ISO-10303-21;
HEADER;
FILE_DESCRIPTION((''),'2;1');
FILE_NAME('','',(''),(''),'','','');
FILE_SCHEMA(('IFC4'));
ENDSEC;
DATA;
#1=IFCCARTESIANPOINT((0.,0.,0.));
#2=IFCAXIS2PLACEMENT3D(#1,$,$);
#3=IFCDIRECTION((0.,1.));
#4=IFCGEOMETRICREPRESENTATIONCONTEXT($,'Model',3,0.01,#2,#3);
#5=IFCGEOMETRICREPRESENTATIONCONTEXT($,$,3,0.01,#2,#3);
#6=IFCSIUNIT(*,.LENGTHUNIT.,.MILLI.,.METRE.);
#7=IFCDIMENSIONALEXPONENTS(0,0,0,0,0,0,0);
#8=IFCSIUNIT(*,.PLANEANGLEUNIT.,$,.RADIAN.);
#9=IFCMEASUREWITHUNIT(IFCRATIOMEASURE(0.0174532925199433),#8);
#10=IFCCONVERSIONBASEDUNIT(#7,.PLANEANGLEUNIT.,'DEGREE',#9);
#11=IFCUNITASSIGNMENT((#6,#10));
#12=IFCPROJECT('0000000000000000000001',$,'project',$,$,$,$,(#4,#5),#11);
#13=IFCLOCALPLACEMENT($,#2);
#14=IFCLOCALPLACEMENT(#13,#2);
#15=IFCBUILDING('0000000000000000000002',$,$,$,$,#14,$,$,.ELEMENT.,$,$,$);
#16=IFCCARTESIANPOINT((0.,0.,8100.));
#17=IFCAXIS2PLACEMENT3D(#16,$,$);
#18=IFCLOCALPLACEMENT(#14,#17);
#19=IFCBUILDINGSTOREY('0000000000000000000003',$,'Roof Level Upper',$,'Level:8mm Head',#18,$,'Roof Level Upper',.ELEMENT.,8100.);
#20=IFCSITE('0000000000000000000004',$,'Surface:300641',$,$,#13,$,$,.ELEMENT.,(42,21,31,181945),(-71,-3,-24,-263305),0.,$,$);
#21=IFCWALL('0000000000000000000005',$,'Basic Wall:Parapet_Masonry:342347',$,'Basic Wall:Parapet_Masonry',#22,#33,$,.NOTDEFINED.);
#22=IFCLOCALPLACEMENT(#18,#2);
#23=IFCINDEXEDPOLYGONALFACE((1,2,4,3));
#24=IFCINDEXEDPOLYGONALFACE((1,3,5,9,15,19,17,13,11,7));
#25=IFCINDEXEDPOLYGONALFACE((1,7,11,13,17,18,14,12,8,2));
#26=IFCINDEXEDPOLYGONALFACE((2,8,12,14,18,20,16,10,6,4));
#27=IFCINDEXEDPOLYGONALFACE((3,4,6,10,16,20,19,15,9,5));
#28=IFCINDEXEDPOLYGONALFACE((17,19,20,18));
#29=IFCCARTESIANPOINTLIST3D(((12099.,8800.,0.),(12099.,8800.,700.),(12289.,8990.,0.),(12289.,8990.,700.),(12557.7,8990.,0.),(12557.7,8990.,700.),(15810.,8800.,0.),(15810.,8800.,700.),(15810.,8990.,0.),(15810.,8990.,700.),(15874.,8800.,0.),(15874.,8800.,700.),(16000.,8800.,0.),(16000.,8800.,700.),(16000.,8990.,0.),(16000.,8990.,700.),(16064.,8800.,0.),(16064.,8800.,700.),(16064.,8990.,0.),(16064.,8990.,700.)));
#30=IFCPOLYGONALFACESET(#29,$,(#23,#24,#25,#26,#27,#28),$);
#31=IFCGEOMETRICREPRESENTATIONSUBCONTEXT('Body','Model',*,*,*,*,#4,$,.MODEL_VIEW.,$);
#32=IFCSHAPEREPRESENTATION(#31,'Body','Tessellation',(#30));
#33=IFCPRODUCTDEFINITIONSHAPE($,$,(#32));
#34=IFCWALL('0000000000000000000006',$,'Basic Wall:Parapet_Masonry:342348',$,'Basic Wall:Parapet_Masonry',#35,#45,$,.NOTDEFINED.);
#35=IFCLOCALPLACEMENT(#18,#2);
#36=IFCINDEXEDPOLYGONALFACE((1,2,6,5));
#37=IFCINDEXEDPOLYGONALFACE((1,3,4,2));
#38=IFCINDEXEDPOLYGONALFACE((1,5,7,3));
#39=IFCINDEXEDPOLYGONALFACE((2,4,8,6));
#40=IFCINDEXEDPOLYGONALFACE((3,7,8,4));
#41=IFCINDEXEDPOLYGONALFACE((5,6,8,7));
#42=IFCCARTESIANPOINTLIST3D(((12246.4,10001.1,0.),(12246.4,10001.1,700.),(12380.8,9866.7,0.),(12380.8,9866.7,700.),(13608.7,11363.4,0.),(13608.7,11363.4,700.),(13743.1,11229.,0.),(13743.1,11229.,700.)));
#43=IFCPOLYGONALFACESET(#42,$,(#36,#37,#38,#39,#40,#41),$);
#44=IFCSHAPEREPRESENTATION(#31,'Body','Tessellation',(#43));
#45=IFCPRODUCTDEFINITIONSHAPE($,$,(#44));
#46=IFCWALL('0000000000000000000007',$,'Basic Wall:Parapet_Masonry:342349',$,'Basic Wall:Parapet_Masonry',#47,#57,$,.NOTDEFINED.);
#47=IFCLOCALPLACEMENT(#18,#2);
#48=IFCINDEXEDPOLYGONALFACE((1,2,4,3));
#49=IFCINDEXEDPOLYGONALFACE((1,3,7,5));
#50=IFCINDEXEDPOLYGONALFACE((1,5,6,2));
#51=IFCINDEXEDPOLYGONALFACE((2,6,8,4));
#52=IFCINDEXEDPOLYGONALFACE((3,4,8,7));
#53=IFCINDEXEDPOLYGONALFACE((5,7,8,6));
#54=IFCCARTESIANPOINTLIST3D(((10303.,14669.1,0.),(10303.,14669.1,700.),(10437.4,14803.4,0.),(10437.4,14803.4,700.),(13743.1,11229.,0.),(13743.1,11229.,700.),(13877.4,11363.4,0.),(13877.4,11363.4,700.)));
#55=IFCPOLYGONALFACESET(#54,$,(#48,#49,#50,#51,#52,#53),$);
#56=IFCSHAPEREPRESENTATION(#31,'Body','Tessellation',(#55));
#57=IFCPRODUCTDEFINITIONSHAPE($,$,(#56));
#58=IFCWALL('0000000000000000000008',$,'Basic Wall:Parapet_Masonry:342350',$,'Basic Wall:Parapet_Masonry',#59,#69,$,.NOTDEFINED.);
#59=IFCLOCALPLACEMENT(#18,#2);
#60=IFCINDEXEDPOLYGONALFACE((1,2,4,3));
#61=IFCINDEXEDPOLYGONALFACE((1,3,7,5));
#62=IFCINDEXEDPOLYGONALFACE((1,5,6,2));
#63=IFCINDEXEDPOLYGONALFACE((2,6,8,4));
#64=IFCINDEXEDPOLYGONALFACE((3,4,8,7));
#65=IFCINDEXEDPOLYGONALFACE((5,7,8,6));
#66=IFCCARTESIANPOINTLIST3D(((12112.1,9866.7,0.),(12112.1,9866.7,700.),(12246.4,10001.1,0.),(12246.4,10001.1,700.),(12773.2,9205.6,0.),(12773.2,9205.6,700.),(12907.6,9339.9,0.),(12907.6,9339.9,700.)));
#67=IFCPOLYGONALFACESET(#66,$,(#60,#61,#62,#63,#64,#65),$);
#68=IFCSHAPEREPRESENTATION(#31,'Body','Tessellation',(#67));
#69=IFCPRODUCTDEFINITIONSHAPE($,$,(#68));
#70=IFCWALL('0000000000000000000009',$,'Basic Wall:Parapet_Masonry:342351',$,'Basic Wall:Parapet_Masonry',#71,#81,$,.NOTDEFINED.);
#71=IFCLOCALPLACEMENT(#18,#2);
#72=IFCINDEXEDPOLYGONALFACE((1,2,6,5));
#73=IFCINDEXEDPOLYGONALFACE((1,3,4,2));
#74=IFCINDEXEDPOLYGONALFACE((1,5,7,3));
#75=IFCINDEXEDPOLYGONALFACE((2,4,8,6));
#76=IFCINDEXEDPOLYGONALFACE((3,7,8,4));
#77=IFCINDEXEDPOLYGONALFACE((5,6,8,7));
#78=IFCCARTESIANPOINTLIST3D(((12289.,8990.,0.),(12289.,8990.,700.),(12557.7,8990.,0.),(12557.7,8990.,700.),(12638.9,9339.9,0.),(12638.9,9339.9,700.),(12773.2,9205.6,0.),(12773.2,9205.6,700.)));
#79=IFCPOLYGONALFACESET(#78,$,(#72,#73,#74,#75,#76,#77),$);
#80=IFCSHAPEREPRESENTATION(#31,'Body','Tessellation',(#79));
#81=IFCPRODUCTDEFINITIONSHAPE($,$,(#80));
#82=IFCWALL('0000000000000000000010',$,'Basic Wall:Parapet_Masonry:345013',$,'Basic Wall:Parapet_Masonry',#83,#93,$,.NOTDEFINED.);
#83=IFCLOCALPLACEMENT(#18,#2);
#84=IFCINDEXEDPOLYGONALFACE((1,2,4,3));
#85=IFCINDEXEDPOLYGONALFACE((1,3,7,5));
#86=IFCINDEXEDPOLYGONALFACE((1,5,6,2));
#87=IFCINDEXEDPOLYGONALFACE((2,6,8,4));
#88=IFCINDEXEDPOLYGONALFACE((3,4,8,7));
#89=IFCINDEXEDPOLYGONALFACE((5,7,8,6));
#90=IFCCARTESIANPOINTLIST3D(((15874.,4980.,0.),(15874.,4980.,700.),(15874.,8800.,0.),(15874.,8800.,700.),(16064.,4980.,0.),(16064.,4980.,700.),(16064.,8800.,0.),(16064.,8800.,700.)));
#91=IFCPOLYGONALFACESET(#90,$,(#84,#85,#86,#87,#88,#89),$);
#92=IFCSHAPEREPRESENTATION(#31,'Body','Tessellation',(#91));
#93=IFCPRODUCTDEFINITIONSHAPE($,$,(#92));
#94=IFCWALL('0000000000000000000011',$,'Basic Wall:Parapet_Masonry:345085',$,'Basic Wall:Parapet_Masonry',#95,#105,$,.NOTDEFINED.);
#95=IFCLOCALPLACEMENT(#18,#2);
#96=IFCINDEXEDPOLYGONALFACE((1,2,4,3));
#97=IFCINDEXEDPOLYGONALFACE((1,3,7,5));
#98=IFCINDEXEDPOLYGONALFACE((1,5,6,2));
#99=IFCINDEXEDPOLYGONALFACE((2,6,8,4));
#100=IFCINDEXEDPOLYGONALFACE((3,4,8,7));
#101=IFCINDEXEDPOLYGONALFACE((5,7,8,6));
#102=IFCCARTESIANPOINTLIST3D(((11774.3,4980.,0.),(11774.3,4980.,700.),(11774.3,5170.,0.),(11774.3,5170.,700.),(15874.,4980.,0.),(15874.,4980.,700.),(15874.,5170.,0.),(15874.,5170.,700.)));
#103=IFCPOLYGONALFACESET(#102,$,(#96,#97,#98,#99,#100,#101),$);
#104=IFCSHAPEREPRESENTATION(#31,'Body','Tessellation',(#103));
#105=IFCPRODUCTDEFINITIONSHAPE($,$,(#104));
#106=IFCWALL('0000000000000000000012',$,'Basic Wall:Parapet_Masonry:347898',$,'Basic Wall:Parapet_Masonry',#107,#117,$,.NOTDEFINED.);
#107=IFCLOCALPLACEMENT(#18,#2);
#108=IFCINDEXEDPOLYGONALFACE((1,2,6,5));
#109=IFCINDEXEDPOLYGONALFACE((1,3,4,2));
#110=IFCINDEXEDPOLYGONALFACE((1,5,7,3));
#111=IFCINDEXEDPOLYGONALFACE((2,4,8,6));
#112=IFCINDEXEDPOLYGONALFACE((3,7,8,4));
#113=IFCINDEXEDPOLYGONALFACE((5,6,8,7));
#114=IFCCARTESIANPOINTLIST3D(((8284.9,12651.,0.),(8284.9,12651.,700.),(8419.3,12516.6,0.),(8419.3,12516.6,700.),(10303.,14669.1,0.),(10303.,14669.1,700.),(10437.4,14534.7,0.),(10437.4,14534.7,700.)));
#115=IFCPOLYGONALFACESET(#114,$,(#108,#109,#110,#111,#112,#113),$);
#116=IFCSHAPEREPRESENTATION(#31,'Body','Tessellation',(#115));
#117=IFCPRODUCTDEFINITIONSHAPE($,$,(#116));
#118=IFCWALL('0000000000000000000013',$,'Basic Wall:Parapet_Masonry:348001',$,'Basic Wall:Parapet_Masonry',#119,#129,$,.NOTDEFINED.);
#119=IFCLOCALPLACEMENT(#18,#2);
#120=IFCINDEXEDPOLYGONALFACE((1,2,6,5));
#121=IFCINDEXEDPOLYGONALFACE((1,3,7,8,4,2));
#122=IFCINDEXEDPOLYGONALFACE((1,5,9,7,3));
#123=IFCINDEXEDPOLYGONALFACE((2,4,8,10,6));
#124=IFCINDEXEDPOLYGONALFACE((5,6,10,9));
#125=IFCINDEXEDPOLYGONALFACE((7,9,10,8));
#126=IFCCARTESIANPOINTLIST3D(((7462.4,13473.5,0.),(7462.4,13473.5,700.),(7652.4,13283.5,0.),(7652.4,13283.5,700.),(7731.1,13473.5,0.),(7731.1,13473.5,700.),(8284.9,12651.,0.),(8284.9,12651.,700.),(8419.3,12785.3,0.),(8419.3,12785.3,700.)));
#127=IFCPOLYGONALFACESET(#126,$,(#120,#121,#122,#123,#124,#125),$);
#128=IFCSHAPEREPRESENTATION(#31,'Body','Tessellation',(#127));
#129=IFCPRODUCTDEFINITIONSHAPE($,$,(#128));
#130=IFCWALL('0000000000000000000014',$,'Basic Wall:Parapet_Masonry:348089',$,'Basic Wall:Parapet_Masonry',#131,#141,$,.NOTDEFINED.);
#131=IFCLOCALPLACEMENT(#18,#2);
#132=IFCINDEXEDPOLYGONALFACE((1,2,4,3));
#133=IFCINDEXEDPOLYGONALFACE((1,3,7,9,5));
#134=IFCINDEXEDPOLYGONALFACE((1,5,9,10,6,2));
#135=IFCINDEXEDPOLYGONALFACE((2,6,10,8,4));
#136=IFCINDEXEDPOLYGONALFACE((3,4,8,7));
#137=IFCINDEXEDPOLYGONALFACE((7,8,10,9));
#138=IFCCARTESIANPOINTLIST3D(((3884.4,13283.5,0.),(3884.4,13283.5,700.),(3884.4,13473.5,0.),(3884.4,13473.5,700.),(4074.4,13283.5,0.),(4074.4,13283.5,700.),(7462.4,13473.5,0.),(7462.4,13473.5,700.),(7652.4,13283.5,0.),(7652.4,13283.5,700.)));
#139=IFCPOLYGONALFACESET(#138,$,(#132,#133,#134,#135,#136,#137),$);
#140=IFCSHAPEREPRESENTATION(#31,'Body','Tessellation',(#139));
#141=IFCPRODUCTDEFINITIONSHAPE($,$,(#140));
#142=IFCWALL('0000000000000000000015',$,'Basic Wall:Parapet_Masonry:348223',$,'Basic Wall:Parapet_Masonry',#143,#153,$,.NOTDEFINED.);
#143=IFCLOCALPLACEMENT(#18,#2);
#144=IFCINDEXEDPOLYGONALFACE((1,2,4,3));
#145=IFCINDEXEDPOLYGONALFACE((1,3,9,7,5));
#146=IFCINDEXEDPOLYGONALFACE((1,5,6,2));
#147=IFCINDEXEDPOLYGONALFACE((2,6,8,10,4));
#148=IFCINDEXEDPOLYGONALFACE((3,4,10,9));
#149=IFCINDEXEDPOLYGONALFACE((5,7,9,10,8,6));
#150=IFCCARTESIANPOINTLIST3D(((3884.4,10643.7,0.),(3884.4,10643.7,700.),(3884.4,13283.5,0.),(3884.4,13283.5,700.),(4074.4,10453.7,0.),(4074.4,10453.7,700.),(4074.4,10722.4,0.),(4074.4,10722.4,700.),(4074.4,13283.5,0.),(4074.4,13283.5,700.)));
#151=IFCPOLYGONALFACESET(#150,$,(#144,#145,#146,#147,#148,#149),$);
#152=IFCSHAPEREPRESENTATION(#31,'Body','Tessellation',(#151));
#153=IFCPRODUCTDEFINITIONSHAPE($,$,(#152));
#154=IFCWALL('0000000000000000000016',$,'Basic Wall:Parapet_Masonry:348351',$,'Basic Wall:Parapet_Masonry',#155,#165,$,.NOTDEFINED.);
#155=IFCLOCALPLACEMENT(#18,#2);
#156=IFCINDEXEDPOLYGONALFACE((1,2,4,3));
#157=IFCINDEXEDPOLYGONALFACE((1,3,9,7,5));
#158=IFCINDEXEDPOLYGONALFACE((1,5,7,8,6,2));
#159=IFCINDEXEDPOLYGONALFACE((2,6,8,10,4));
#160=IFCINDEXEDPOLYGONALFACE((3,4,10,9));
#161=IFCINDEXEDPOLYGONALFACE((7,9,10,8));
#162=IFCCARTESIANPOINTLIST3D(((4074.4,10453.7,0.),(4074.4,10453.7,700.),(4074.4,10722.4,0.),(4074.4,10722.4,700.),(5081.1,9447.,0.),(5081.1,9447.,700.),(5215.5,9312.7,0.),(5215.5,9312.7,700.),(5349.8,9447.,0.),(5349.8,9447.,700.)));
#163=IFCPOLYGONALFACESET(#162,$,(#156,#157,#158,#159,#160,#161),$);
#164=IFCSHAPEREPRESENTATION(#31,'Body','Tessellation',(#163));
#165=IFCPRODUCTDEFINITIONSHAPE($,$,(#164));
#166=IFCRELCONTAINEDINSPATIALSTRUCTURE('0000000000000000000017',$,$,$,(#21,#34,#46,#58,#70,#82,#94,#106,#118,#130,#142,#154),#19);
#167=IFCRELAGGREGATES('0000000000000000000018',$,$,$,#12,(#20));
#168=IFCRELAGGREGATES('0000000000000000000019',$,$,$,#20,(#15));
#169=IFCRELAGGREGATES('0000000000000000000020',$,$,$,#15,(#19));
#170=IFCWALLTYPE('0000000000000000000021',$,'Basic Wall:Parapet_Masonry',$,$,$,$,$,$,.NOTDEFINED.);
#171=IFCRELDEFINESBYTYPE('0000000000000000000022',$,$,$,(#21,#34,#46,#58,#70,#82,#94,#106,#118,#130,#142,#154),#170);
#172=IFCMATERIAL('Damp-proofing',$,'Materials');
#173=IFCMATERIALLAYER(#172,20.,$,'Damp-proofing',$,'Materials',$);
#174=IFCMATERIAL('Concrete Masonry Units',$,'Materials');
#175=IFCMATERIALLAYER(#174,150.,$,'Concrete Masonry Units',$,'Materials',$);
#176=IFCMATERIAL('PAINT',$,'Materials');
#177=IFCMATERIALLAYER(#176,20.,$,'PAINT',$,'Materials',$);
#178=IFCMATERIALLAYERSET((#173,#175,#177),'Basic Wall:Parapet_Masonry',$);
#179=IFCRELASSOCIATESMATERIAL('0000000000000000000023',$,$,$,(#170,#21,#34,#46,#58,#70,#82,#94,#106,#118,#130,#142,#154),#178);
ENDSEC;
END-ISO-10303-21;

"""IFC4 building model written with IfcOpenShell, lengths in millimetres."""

from ifc_helpers import new_model, entity, si_unit, converted_unit, direction, frame, frame_2d, origin, place, context, subcontext, project, spatial, polyline, rectangle, outline, extrude, material, layer, layer_set, layer_usage, type_object, element, save


model = new_model("IFC4")

# Units and contexts
model_context = context("Model", 3, precision=0.01, world=origin(), true_north=direction((0.0, 1.0)))
context_of_model = context(None, 3, precision=0.01, world=origin(), true_north=direction((0.0, 1.0)))
body_context = subcontext(model_context, "Body", "Model", "MODEL_VIEW")
ifc_project = project(units=[si_unit("LENGTHUNIT", "METRE", prefix="MILLI"), converted_unit("PLANEANGLEUNIT", "DEGREE", entity("IfcRatioMeasure", 0.0174532925199433), si_unit("PLANEANGLEUNIT", "RADIAN"), dimensions=[0, 0, 0, 0, 0, 0, 0])], contexts=[model_context, context_of_model])

# Site, building, storey
site_placement = place(None, origin())
site = spatial("IfcSite", under=ifc_project, at=site_placement, Name="Surface:300641", CompositionType="ELEMENT", RefLatitude=(42, 21, 31, 181945), RefLongitude=(-71, -3, -24, -263305), RefElevation=0.0)
building_placement = place(site_placement, origin())
building = spatial("IfcBuilding", under=site, at=building_placement, CompositionType="ELEMENT")
storey_placement = place(building_placement, frame((0.0, 0.0, 8100.0)))
storey = spatial("IfcBuildingStorey", under=building, at=storey_placement, Name="Roof Level Upper", ObjectType="Level:8mm Head", LongName="Roof Level Upper", CompositionType="ELEMENT", Elevation=8100.0)

# Shared definitions
ifc_material_1 = material(Name="Damp-proofing", Category="Materials")

# Walls
ifc_layer_1 = layer(ifc_material_1, 20.0, Name="Damp-proofing", Category="Materials")
ifc_material_2 = material(Name="Concrete Masonry Units", Category="Materials")
ifc_layer_2 = layer(ifc_material_2, 150.0, Name="Concrete Masonry Units", Category="Materials")
ifc_material_3 = material(Name="PAINT", Category="Materials")
ifc_layer_3 = layer(ifc_material_3, 20.0, Name="PAINT", Category="Materials")
ifc_layer_set_1 = layer_set([ifc_layer_1, ifc_layer_2, ifc_layer_3], Name="Basic Wall:Parapet_Masonry")
ifc_layer_usage_1 = layer_usage(ifc_layer_set_1, "AXIS2", "NEGATIVE", 95.0)
wall_type = type_object("IfcWallType", Name="Basic Wall:Parapet_Masonry", PredefinedType="NOTDEFINED", material=ifc_layer_set_1)
wall_1_placement = place(storey_placement, frame((16064.0, 8895.0, 0.0), z_axis=(0.0, 0.0, 1.0), x_axis=(-1.0, 0.0, 0.0)))
element("IfcWall", 1, at=wall_1_placement, inside=storey, type_object=wall_type, material=ifc_layer_usage_1, Name="Basic Wall:Parapet_Masonry:342347", ObjectType="Basic Wall:Parapet_Masonry", PredefinedType="NOTDEFINED", context=body_context, shape_type="SweptSolid", body=[
    extrude(outline(polyline([(3775.0, -95.0), (3965.0, 95.0), (254.0, 95.0), (190.0, 95.0), (64.0, 95.0), (0.0, 95.0), (0.0, -95.0), (64.0, -95.0), (254.0, -95.0), (3506.3, -95.0), (3775.0, -95.0)])), origin(), (0.0, 0.0, 1.0), 700.0),
])
ifc_layer_usage_2 = layer_usage(ifc_layer_set_1, "AXIS2", "POSITIVE", -95.0)
wall_2_placement = place(storey_placement, frame((13675.9, 11296.2, 0.0), z_axis=(0.0, 0.0, 1.0), x_axis=(-0.707107, -0.707107, 0.0)))
element("IfcWall", 2, at=wall_2_placement, inside=storey, type_object=wall_type, material=ifc_layer_usage_2, Name="Basic Wall:Parapet_Masonry:342348", ObjectType="Basic Wall:Parapet_Masonry", PredefinedType="NOTDEFINED", context=body_context, shape_type="SweptSolid", body=[
    extrude(rectangle(XDim=1926.6, YDim=190.0, at=frame_2d((963.3, 0.0), x_axis=(-1.0, 0.0))), origin(), (0.0, 0.0, 1.0), 700.0),
])
ifc_layer_usage_3 = layer_usage(ifc_layer_set_1, "AXIS2", "POSITIVE", -95.0)
wall_3_placement = place(storey_placement, frame((10370.2, 14736.3, 0.0), z_axis=(0.0, 0.0, 1.0), x_axis=(0.707107, -0.707107, 0.0)))
element("IfcWall", 3, at=wall_3_placement, inside=storey, type_object=wall_type, material=ifc_layer_usage_3, Name="Basic Wall:Parapet_Masonry:342349", ObjectType="Basic Wall:Parapet_Masonry", PredefinedType="NOTDEFINED", context=body_context, shape_type="SweptSolid", body=[
    extrude(rectangle(XDim=4865.0, YDim=190.0, at=frame_2d((2432.5, 0.0), x_axis=(-1.0, 0.0))), origin(), (0.0, 0.0, 1.0), 700.0),
])
ifc_layer_usage_4 = layer_usage(ifc_layer_set_1, "AXIS2", "POSITIVE", -95.0)
wall_4_placement = place(storey_placement, frame((12179.3, 9933.9, 0.0), z_axis=(0.0, 0.0, 1.0), x_axis=(0.707107, -0.707107, 0.0)))
element("IfcWall", 4, at=wall_4_placement, inside=storey, type_object=wall_type, material=ifc_layer_usage_4, Name="Basic Wall:Parapet_Masonry:342350", ObjectType="Basic Wall:Parapet_Masonry", PredefinedType="NOTDEFINED", context=body_context, shape_type="SweptSolid", body=[
    extrude(rectangle(XDim=935.0, YDim=190.0, at=frame_2d((467.5, 0.0), x_axis=(-1.0, 0.0))), origin(), (0.0, 0.0, 1.0), 700.0),
])
ifc_layer_usage_5 = layer_usage(ifc_layer_set_1, "AXIS2", "POSITIVE", -95.0)
wall_5_placement = place(storey_placement, frame((12706.1, 9272.7, 0.0), z_axis=(0.0, 0.0, 1.0), x_axis=(-0.707107, -0.707107, 0.0)))
element("IfcWall", 5, at=wall_5_placement, inside=storey, type_object=wall_type, material=ifc_layer_usage_5, Name="Basic Wall:Parapet_Masonry:342351", ObjectType="Basic Wall:Parapet_Masonry", PredefinedType="NOTDEFINED", context=body_context, shape_type="SweptSolid", body=[
    extrude(outline(polyline([(494.8, -95.0), (304.8, 95.0), (0.0, 95.0), (0.0, -95.0), (494.8, -95.0)])), origin(), (0.0, 0.0, 1.0), 700.0),
])
ifc_layer_usage_6 = layer_usage(ifc_layer_set_1, "AXIS2", "POSITIVE", -95.0)
wall_6_placement = place(storey_placement, frame((15969.0, 8800.0, 0.0), z_axis=(0.0, 0.0, 1.0), x_axis=(0.0, -1.0, 0.0)))
element("IfcWall", 6, at=wall_6_placement, inside=storey, type_object=wall_type, material=ifc_layer_usage_6, Name="Basic Wall:Parapet_Masonry:345013", ObjectType="Basic Wall:Parapet_Masonry", PredefinedType="NOTDEFINED", context=body_context, shape_type="SweptSolid", body=[
    extrude(rectangle(XDim=3820.0, YDim=190.0, at=frame_2d((1910.0, 0.0), x_axis=(-1.0, 0.0))), origin(), (0.0, 0.0, 1.0), 700.0),
])
ifc_layer_usage_7 = layer_usage(ifc_layer_set_1, "AXIS2", "NEGATIVE", 95.0)
wall_7_placement = place(storey_placement, frame((11774.3, 5075.0, 0.0)))
element("IfcWall", 7, at=wall_7_placement, inside=storey, type_object=wall_type, material=ifc_layer_usage_7, Name="Basic Wall:Parapet_Masonry:345085", ObjectType="Basic Wall:Parapet_Masonry", PredefinedType="NOTDEFINED", context=body_context, shape_type="SweptSolid", body=[
    extrude(rectangle(XDim=4099.7, YDim=190.0, at=frame_2d((2049.9, 0.0), x_axis=(-1.0, 0.0))), origin(), (0.0, 0.0, 1.0), 700.0),
])
ifc_layer_usage_8 = layer_usage(ifc_layer_set_1, "AXIS2", "NEGATIVE", 95.0)
wall_8_placement = place(storey_placement, frame((10370.2, 14601.9, 0.0), z_axis=(0.0, 0.0, 1.0), x_axis=(-0.707107, -0.707107, 0.0)))
element("IfcWall", 8, at=wall_8_placement, inside=storey, type_object=wall_type, material=ifc_layer_usage_8, Name="Basic Wall:Parapet_Masonry:347898", ObjectType="Basic Wall:Parapet_Masonry", PredefinedType="NOTDEFINED", context=body_context, shape_type="SweptSolid", body=[
    extrude(rectangle(XDim=2854.0, YDim=190.0, at=frame_2d((1427.0, 0.0), x_axis=(-1.0, 0.0))), origin(), (0.0, 0.0, 1.0), 700.0),
])
ifc_layer_usage_9 = layer_usage(ifc_layer_set_1, "AXIS2", "POSITIVE", -95.0)
wall_9_placement = place(storey_placement, frame((7529.6, 13540.6, 0.0), z_axis=(0.0, 0.0, 1.0), x_axis=(0.707107, -0.707107, 0.0)))
element("IfcWall", 9, at=wall_9_placement, inside=storey, type_object=wall_type, material=ifc_layer_usage_9, Name="Basic Wall:Parapet_Masonry:348001", ObjectType="Basic Wall:Parapet_Masonry", PredefinedType="NOTDEFINED", context=body_context, shape_type="SweptSolid", body=[
    extrude(outline(polyline([(1163.2, -95.0), (1163.2, 95.0), (190.0, 95.0), (0.0, -95.0), (268.7, -95.0), (1163.2, -95.0)])), origin(), (0.0, 0.0, 1.0), 700.0),
])
ifc_layer_usage_10 = layer_usage(ifc_layer_set_1, "AXIS2", "NEGATIVE", 95.0)
wall_10_placement = place(storey_placement, frame((7652.4, 13378.5, 0.0), z_axis=(0.0, 0.0, 1.0), x_axis=(-1.0, 0.0, 0.0)))
element("IfcWall", 10, at=wall_10_placement, inside=storey, type_object=wall_type, material=ifc_layer_usage_10, Name="Basic Wall:Parapet_Masonry:348089", ObjectType="Basic Wall:Parapet_Masonry", PredefinedType="NOTDEFINED", context=body_context, shape_type="SweptSolid", body=[
    extrude(outline(polyline([(3768.0, -95.0), (3768.0, 95.0), (3578.0, 95.0), (0.0, 95.0), (190.0, -95.0), (3768.0, -95.0)])), origin(), (0.0, 0.0, 1.0), 700.0),
])
ifc_layer_usage_11 = layer_usage(ifc_layer_set_1, "AXIS2", "NEGATIVE", 95.0)
wall_11_placement = place(storey_placement, frame((3979.4, 13283.5, 0.0), z_axis=(0.0, 0.0, 1.0), x_axis=(0.0, -1.0, 0.0)))
element("IfcWall", 11, at=wall_11_placement, inside=storey, type_object=wall_type, material=ifc_layer_usage_11, Name="Basic Wall:Parapet_Masonry:348223", ObjectType="Basic Wall:Parapet_Masonry", PredefinedType="NOTDEFINED", context=body_context, shape_type="SweptSolid", body=[
    extrude(outline(polyline([(2639.8, -95.0), (2829.8, 95.0), (2561.1, 95.0), (0.0, 95.0), (0.0, -95.0), (2639.8, -95.0)])), origin(), (0.0, 0.0, 1.0), 700.0),
])
ifc_layer_usage_12 = layer_usage(ifc_layer_set_1, "AXIS2", "NEGATIVE", 95.0)
wall_12_placement = place(storey_placement, frame((4007.3, 10655.2, 0.0), z_axis=(0.0, 0.0, 1.0), x_axis=(0.707107, -0.707107, 0.0)))
element("IfcWall", 12, at=wall_12_placement, inside=storey, type_object=wall_type, material=ifc_layer_usage_12, Name="Basic Wall:Parapet_Masonry:348351", ObjectType="Basic Wall:Parapet_Masonry", PredefinedType="NOTDEFINED", context=body_context, shape_type="SweptSolid", body=[
    extrude(outline(polyline([(1803.7, -95.0), (1803.7, 95.0), (0.0, 95.0), (190.0, -95.0), (1613.7, -95.0), (1803.7, -95.0)])), origin(), (0.0, 0.0, 1.0), 700.0),
])

save(model, "model.ifc")
